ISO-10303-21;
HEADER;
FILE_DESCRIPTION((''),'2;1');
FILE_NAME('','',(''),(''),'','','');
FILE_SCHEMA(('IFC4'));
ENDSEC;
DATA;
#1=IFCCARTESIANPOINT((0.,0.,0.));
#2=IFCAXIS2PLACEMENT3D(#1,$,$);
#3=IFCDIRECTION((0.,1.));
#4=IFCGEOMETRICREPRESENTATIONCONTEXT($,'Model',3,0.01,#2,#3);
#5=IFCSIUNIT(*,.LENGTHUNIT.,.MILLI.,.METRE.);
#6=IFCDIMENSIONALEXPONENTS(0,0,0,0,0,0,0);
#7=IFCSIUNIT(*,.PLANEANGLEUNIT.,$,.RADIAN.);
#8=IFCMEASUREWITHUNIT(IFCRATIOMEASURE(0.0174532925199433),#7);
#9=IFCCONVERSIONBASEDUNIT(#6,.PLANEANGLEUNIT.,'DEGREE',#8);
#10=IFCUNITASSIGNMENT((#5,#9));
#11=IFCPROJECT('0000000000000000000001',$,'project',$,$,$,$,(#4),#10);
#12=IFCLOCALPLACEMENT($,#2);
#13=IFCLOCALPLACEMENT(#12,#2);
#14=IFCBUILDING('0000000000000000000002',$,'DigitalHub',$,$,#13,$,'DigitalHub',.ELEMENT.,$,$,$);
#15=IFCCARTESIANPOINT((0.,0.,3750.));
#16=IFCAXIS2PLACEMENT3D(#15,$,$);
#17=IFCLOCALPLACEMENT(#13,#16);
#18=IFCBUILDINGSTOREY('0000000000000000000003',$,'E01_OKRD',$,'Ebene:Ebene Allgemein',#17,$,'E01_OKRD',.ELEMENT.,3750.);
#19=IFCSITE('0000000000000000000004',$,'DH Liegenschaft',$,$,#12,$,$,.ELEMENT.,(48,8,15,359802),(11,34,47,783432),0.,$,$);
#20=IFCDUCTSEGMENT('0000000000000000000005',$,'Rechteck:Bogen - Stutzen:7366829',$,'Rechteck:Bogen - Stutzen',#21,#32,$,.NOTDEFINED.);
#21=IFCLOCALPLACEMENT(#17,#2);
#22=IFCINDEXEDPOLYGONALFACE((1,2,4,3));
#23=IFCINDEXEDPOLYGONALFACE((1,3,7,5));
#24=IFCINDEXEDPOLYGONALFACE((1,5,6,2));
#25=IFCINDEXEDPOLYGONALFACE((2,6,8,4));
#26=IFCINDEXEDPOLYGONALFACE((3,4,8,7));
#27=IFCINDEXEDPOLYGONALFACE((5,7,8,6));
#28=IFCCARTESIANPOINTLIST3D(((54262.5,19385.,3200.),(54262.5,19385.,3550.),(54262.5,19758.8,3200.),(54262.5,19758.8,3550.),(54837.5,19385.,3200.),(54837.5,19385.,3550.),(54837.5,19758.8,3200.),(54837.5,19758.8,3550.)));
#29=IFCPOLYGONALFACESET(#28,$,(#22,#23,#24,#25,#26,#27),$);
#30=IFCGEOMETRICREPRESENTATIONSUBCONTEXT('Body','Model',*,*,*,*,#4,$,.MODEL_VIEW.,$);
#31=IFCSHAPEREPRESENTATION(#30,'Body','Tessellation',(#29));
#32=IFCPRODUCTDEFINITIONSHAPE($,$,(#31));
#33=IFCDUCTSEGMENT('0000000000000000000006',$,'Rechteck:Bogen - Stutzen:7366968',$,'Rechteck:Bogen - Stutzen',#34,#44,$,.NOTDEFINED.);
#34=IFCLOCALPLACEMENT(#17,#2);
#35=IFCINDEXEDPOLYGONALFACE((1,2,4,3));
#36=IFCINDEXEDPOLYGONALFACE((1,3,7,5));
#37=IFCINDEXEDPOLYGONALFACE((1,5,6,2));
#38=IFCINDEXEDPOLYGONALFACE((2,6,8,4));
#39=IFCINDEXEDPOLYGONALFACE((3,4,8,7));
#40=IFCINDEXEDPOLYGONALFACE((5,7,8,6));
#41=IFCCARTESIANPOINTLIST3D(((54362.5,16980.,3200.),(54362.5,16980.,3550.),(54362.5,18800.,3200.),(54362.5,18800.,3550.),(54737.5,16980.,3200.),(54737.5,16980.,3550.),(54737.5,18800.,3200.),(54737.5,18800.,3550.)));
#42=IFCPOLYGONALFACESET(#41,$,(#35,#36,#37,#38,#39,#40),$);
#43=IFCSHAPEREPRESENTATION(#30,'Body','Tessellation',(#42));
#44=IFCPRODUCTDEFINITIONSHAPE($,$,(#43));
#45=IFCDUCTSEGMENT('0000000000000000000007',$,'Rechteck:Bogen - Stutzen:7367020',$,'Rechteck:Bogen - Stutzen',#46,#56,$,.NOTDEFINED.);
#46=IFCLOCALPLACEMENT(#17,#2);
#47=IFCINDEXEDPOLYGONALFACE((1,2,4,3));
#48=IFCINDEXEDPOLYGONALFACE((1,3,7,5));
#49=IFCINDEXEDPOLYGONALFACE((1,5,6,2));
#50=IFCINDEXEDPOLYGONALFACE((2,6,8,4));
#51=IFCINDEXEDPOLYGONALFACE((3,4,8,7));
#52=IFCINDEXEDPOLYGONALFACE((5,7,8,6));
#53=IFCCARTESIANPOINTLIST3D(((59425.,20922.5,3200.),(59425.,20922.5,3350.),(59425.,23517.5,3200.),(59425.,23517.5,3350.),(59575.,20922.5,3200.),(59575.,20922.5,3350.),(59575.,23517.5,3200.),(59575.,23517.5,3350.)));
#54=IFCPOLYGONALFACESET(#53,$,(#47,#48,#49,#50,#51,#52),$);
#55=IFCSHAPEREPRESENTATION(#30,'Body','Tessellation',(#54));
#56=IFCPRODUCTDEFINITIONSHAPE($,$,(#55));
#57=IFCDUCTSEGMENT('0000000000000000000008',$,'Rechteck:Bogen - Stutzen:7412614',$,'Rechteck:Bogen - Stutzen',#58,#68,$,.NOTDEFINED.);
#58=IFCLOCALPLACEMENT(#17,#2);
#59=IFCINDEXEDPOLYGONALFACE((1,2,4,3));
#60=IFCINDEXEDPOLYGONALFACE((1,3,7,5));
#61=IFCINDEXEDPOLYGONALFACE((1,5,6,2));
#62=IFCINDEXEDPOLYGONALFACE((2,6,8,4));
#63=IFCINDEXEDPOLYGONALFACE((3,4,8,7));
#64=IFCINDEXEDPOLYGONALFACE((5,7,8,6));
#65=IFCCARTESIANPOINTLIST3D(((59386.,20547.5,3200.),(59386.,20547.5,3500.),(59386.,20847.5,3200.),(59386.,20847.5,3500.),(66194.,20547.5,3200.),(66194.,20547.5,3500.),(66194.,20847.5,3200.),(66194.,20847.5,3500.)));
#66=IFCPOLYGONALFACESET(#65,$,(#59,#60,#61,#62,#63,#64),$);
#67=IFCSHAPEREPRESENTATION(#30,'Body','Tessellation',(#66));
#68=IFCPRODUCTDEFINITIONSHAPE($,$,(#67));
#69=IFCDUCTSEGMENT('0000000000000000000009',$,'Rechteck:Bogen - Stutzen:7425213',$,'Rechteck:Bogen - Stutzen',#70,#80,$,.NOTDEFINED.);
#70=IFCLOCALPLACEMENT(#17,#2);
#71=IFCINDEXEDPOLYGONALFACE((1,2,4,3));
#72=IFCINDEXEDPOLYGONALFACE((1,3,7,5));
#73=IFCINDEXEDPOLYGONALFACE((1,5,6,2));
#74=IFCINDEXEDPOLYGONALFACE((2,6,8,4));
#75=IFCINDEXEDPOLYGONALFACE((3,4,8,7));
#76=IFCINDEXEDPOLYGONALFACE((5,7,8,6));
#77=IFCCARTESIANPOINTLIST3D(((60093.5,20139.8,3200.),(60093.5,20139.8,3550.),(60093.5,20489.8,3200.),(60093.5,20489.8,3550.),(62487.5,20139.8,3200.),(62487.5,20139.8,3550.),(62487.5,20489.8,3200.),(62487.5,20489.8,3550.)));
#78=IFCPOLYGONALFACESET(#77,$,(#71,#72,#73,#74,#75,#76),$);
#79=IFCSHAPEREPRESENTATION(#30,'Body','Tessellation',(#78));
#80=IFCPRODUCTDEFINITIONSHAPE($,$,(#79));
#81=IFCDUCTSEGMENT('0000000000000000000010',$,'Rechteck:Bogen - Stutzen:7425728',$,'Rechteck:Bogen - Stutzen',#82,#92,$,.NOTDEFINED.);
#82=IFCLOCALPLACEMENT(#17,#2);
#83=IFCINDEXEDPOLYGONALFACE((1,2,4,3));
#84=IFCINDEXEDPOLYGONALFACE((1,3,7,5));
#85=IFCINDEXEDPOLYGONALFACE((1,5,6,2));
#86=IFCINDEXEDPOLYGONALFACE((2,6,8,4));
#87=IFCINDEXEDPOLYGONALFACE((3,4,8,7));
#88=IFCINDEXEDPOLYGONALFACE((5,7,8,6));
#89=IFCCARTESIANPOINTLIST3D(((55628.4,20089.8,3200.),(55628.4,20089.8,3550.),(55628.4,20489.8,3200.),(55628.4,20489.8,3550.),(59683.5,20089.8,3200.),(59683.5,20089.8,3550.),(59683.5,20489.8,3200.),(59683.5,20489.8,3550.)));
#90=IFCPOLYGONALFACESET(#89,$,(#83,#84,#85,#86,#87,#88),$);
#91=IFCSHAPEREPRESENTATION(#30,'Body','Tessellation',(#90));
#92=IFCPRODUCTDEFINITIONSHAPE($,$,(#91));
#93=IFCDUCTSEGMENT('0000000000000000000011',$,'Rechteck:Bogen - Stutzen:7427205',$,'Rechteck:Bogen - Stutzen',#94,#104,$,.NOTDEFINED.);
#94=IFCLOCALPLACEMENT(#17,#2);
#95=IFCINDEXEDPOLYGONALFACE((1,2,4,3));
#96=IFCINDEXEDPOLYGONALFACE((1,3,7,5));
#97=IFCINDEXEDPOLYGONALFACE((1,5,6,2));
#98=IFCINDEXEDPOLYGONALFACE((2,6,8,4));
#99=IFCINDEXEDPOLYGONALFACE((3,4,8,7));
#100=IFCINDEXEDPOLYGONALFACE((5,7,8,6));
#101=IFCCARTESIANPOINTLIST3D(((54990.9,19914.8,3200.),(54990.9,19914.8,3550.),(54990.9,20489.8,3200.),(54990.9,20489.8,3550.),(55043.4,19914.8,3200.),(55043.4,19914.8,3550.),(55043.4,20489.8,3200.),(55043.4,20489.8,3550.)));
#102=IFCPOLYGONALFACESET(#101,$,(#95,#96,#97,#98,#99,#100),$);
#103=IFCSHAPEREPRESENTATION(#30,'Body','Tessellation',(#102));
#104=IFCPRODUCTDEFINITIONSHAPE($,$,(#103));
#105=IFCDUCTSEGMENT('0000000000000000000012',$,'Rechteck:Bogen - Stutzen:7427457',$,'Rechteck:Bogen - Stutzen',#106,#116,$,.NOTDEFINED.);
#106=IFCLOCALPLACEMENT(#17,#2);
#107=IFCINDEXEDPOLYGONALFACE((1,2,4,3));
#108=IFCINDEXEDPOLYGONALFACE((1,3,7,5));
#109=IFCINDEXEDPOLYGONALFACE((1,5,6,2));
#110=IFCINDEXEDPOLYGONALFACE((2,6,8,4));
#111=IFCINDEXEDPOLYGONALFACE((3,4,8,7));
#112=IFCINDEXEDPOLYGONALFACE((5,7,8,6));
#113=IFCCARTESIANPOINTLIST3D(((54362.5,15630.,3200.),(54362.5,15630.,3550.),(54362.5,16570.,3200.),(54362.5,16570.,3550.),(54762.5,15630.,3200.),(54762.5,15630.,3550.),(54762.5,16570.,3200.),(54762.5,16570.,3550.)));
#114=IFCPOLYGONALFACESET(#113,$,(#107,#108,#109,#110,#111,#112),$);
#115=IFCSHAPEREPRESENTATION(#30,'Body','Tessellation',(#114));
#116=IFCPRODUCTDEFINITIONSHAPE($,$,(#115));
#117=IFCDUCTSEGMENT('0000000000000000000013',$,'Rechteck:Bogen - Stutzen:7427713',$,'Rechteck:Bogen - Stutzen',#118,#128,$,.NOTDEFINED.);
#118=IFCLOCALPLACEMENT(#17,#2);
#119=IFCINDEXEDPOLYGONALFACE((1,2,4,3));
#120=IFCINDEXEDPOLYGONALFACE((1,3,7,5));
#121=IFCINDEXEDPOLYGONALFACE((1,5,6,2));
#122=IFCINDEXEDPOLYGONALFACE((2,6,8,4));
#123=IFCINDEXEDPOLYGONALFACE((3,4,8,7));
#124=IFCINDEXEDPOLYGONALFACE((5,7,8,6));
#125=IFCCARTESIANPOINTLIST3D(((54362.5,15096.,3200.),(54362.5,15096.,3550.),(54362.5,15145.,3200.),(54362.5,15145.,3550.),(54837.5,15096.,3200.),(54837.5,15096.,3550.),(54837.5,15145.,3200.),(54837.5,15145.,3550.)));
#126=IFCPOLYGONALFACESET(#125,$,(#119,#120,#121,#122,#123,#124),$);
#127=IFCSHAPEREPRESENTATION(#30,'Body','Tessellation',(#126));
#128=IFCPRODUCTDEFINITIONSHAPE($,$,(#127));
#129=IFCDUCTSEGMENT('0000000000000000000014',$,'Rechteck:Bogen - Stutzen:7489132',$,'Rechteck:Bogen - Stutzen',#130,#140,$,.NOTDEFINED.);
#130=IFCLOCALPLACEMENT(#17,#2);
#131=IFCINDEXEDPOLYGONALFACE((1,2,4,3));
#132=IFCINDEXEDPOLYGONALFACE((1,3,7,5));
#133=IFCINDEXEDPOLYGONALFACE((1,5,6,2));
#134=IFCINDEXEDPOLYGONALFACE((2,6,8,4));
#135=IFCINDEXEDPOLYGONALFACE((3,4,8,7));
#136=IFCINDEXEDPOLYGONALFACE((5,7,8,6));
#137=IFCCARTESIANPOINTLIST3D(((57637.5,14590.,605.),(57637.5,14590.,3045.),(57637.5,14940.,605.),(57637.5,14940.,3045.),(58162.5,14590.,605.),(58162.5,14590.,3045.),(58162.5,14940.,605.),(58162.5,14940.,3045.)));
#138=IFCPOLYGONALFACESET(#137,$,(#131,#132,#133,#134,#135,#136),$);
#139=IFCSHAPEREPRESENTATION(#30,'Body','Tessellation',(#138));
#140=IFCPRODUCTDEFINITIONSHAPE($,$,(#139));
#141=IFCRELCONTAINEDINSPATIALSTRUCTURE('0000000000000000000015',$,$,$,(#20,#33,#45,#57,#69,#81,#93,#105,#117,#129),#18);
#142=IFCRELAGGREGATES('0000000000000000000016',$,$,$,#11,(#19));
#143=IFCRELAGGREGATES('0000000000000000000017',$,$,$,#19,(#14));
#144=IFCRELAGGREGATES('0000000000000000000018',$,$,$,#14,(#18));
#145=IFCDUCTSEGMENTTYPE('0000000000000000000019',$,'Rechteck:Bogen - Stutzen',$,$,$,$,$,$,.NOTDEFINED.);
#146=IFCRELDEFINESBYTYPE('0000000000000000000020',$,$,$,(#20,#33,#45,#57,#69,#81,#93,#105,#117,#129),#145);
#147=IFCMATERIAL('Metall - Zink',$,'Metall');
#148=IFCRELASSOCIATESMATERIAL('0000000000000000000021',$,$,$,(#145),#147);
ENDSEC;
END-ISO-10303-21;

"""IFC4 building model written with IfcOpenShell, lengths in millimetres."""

from ifc_helpers import new_model, entity, si_unit, converted_unit, direction, frame, origin, place, context, subcontext, project, spatial, indexed_curve, outline, extrude, material, type_object, element, save


model = new_model("IFC4")

# Units and contexts
model_context = context("Model", 3, precision=0.01, world=origin(), true_north=direction((0.0, 1.0)))
body_context = subcontext(model_context, "Body", "Model", "MODEL_VIEW")
ifc_project = project(units=[si_unit("LENGTHUNIT", "METRE", prefix="MILLI"), converted_unit("PLANEANGLEUNIT", "DEGREE", entity("IfcRatioMeasure", 0.0174532925199433), si_unit("PLANEANGLEUNIT", "RADIAN"), dimensions=[0, 0, 0, 0, 0, 0, 0])], contexts=[model_context])

# Site, building, storey
site_placement = place(None, origin())
site = spatial("IfcSite", under=ifc_project, at=site_placement, Name="DH Liegenschaft", CompositionType="ELEMENT", RefLatitude=(48, 8, 15, 359802), RefLongitude=(11, 34, 47, 783432), RefElevation=0.0)
building_placement = place(site_placement, origin())
building = spatial("IfcBuilding", under=site, at=building_placement, Name="DigitalHub", LongName="DigitalHub", CompositionType="ELEMENT")
storey_placement = place(building_placement, frame((0.0, 0.0, 3750.0)))
storey = spatial("IfcBuildingStorey", under=building, at=storey_placement, Name="E01_OKRD", ObjectType="Ebene:Ebene Allgemein", LongName="E01_OKRD", CompositionType="ELEMENT", Elevation=3750.0)

# Duct segments
ifc_material_1 = material(Name="Metall - Zink", Category="Metall")
duct_segment_type_1 = type_object("IfcDuctSegmentType", Name="Rechteck:Bogen - Stutzen", PredefinedType="NOTDEFINED", material=ifc_material_1)
duct_segment_1_placement = place(storey_placement, frame((54262.5, 19385.0, 3200.0)))
element("IfcDuctSegment", 1, at=duct_segment_1_placement, inside=storey, type_object=duct_segment_type_1, Name="Rechteck:Bogen - Stutzen:7366829", ObjectType="Rechteck:Bogen - Stutzen", PredefinedType="NOTDEFINED", context=body_context, shape_type="SweptSolid", body=[
    extrude(outline(indexed_curve([(-186.9, -287.5), (186.9, -287.5), (186.9, 287.5), (-186.9, 287.5), (-186.9, -287.5)], self_intersect=False)), frame((287.5, 186.9, 0.0), z_axis=(0.0, 0.0, 1.0), x_axis=(0.0, 1.0, 0.0)), (0.0, 0.0, 1.0), 350.0),
])
duct_segment_2_placement = place(storey_placement, frame((54362.5, 16980.0, 3200.0)))
element("IfcDuctSegment", 2, at=duct_segment_2_placement, inside=storey, type_object=duct_segment_type_1, Name="Rechteck:Bogen - Stutzen:7366968", ObjectType="Rechteck:Bogen - Stutzen", PredefinedType="NOTDEFINED", context=body_context, shape_type="SweptSolid", body=[
    extrude(outline(indexed_curve([(-910.0, -187.5), (910.0, -187.5), (910.0, 187.5), (-910.0, 187.5), (-910.0, -187.5)], self_intersect=False)), frame((187.5, 910.0, 0.0), z_axis=(0.0, 0.0, 1.0), x_axis=(0.0, -1.0, 0.0)), (0.0, 0.0, 1.0), 350.0),
])
duct_segment_3_placement = place(storey_placement, frame((59425.0, 20922.5, 3200.0)))
element("IfcDuctSegment", 3, at=duct_segment_3_placement, inside=storey, type_object=duct_segment_type_1, Name="Rechteck:Bogen - Stutzen:7367020", ObjectType="Rechteck:Bogen - Stutzen", PredefinedType="NOTDEFINED", context=body_context, shape_type="SweptSolid", body=[
    extrude(outline(indexed_curve([(-1297.5, -75.0), (1297.5, -75.0), (1297.5, 75.0), (-1297.5, 75.0), (-1297.5, -75.0)], self_intersect=False)), frame((75.0, 1297.5, 0.0), z_axis=(0.0, 0.0, 1.0), x_axis=(0.0, 1.0, 0.0)), (0.0, 0.0, 1.0), 150.0),
])
duct_segment_4_placement = place(storey_placement, frame((59386.0, 20547.5, 3200.0)))
element("IfcDuctSegment", 4, at=duct_segment_4_placement, inside=storey, type_object=duct_segment_type_1, Name="Rechteck:Bogen - Stutzen:7412614", ObjectType="Rechteck:Bogen - Stutzen", PredefinedType="NOTDEFINED", context=body_context, shape_type="SweptSolid", body=[
    extrude(outline(indexed_curve([(-3404.0, -150.0), (3404.0, -150.0), (3404.0, 150.0), (-3404.0, 150.0), (-3404.0, -150.0)], self_intersect=False)), frame((3404.0, 150.0, 0.0)), (0.0, 0.0, 1.0), 300.0),
])
duct_segment_5_placement = place(storey_placement, frame((60093.5, 20139.8, 3200.0)))
element("IfcDuctSegment", 5, at=duct_segment_5_placement, inside=storey, type_object=duct_segment_type_1, Name="Rechteck:Bogen - Stutzen:7425213", ObjectType="Rechteck:Bogen - Stutzen", PredefinedType="NOTDEFINED", context=body_context, shape_type="SweptSolid", body=[
    extrude(outline(indexed_curve([(-1197.0, -175.0), (1197.0, -175.0), (1197.0, 175.0), (-1197.0, 175.0), (-1197.0, -175.0)], self_intersect=False)), frame((1197.0, 175.0, 0.0)), (0.0, 0.0, 1.0), 350.0),
])
duct_segment_6_placement = place(storey_placement, frame((55628.4, 20089.8, 3200.0)))
element("IfcDuctSegment", 6, at=duct_segment_6_placement, inside=storey, type_object=duct_segment_type_1, Name="Rechteck:Bogen - Stutzen:7425728", ObjectType="Rechteck:Bogen - Stutzen", PredefinedType="NOTDEFINED", context=body_context, shape_type="SweptSolid", body=[
    extrude(outline(indexed_curve([(-2027.6, -200.0), (2027.6, -200.0), (2027.6, 200.0), (-2027.6, 200.0), (-2027.6, -200.0)], self_intersect=False)), frame((2027.6, 200.0, 0.0)), (0.0, 0.0, 1.0), 350.0),
])
duct_segment_7_placement = place(storey_placement, frame((54990.9, 19914.8, 3200.0)))
element("IfcDuctSegment", 7, at=duct_segment_7_placement, inside=storey, type_object=duct_segment_type_1, Name="Rechteck:Bogen - Stutzen:7427205", ObjectType="Rechteck:Bogen - Stutzen", PredefinedType="NOTDEFINED", context=body_context, shape_type="SweptSolid", body=[
    extrude(outline(indexed_curve([(-26.2, -287.5), (26.3, -287.5), (26.2, 287.5), (-26.3, 287.5), (-26.2, -287.5)], self_intersect=False)), frame((26.2, 287.5, 0.0), z_axis=(0.0, 0.0, 1.0), x_axis=(-1.0, 0.0, 0.0)), (0.0, 0.0, 1.0), 350.0),
])
duct_segment_8_placement = place(storey_placement, frame((54362.5, 15630.0, 3200.0)))
element("IfcDuctSegment", 8, at=duct_segment_8_placement, inside=storey, type_object=duct_segment_type_1, Name="Rechteck:Bogen - Stutzen:7427457", ObjectType="Rechteck:Bogen - Stutzen", PredefinedType="NOTDEFINED", context=body_context, shape_type="SweptSolid", body=[
    extrude(outline(indexed_curve([(-470.0, -200.0), (470.0, -200.0), (470.0, 200.0), (-470.0, 200.0), (-470.0, -200.0)], self_intersect=False)), frame((200.0, 470.0, 0.0), z_axis=(0.0, 0.0, 1.0), x_axis=(0.0, -1.0, 0.0)), (0.0, 0.0, 1.0), 350.0),
])
duct_segment_9_placement = place(storey_placement, frame((54362.5, 15096.0, 3200.0)))
element("IfcDuctSegment", 9, at=duct_segment_9_placement, inside=storey, type_object=duct_segment_type_1, Name="Rechteck:Bogen - Stutzen:7427713", ObjectType="Rechteck:Bogen - Stutzen", PredefinedType="NOTDEFINED", context=body_context, shape_type="SweptSolid", body=[
    extrude(outline(indexed_curve([(-24.5, -237.5), (24.5, -237.5), (24.5, 237.5), (-24.5, 237.5), (-24.5, -237.5)], self_intersect=False)), frame((237.5, 24.5, 0.0), z_axis=(0.0, 0.0, 1.0), x_axis=(0.0, 1.0, 0.0)), (0.0, 0.0, 1.0), 350.0),
])
duct_segment_10_placement = place(storey_placement, frame((57637.5, 14590.0, 605.0)))
element("IfcDuctSegment", 10, at=duct_segment_10_placement, inside=storey, type_object=duct_segment_type_1, Name="Rechteck:Bogen - Stutzen:7489132", ObjectType="Rechteck:Bogen - Stutzen", PredefinedType="NOTDEFINED", context=body_context, shape_type="SweptSolid", body=[
    extrude(outline(indexed_curve([(-262.5, -175.0), (262.5, -175.0), (262.5, 175.0), (-262.5, 175.0), (-262.5, -175.0)], self_intersect=False)), frame((262.5, 175.0, 0.0)), (0.0, 0.0, 1.0), 2440.0),
])

save(model, "model.ifc")
